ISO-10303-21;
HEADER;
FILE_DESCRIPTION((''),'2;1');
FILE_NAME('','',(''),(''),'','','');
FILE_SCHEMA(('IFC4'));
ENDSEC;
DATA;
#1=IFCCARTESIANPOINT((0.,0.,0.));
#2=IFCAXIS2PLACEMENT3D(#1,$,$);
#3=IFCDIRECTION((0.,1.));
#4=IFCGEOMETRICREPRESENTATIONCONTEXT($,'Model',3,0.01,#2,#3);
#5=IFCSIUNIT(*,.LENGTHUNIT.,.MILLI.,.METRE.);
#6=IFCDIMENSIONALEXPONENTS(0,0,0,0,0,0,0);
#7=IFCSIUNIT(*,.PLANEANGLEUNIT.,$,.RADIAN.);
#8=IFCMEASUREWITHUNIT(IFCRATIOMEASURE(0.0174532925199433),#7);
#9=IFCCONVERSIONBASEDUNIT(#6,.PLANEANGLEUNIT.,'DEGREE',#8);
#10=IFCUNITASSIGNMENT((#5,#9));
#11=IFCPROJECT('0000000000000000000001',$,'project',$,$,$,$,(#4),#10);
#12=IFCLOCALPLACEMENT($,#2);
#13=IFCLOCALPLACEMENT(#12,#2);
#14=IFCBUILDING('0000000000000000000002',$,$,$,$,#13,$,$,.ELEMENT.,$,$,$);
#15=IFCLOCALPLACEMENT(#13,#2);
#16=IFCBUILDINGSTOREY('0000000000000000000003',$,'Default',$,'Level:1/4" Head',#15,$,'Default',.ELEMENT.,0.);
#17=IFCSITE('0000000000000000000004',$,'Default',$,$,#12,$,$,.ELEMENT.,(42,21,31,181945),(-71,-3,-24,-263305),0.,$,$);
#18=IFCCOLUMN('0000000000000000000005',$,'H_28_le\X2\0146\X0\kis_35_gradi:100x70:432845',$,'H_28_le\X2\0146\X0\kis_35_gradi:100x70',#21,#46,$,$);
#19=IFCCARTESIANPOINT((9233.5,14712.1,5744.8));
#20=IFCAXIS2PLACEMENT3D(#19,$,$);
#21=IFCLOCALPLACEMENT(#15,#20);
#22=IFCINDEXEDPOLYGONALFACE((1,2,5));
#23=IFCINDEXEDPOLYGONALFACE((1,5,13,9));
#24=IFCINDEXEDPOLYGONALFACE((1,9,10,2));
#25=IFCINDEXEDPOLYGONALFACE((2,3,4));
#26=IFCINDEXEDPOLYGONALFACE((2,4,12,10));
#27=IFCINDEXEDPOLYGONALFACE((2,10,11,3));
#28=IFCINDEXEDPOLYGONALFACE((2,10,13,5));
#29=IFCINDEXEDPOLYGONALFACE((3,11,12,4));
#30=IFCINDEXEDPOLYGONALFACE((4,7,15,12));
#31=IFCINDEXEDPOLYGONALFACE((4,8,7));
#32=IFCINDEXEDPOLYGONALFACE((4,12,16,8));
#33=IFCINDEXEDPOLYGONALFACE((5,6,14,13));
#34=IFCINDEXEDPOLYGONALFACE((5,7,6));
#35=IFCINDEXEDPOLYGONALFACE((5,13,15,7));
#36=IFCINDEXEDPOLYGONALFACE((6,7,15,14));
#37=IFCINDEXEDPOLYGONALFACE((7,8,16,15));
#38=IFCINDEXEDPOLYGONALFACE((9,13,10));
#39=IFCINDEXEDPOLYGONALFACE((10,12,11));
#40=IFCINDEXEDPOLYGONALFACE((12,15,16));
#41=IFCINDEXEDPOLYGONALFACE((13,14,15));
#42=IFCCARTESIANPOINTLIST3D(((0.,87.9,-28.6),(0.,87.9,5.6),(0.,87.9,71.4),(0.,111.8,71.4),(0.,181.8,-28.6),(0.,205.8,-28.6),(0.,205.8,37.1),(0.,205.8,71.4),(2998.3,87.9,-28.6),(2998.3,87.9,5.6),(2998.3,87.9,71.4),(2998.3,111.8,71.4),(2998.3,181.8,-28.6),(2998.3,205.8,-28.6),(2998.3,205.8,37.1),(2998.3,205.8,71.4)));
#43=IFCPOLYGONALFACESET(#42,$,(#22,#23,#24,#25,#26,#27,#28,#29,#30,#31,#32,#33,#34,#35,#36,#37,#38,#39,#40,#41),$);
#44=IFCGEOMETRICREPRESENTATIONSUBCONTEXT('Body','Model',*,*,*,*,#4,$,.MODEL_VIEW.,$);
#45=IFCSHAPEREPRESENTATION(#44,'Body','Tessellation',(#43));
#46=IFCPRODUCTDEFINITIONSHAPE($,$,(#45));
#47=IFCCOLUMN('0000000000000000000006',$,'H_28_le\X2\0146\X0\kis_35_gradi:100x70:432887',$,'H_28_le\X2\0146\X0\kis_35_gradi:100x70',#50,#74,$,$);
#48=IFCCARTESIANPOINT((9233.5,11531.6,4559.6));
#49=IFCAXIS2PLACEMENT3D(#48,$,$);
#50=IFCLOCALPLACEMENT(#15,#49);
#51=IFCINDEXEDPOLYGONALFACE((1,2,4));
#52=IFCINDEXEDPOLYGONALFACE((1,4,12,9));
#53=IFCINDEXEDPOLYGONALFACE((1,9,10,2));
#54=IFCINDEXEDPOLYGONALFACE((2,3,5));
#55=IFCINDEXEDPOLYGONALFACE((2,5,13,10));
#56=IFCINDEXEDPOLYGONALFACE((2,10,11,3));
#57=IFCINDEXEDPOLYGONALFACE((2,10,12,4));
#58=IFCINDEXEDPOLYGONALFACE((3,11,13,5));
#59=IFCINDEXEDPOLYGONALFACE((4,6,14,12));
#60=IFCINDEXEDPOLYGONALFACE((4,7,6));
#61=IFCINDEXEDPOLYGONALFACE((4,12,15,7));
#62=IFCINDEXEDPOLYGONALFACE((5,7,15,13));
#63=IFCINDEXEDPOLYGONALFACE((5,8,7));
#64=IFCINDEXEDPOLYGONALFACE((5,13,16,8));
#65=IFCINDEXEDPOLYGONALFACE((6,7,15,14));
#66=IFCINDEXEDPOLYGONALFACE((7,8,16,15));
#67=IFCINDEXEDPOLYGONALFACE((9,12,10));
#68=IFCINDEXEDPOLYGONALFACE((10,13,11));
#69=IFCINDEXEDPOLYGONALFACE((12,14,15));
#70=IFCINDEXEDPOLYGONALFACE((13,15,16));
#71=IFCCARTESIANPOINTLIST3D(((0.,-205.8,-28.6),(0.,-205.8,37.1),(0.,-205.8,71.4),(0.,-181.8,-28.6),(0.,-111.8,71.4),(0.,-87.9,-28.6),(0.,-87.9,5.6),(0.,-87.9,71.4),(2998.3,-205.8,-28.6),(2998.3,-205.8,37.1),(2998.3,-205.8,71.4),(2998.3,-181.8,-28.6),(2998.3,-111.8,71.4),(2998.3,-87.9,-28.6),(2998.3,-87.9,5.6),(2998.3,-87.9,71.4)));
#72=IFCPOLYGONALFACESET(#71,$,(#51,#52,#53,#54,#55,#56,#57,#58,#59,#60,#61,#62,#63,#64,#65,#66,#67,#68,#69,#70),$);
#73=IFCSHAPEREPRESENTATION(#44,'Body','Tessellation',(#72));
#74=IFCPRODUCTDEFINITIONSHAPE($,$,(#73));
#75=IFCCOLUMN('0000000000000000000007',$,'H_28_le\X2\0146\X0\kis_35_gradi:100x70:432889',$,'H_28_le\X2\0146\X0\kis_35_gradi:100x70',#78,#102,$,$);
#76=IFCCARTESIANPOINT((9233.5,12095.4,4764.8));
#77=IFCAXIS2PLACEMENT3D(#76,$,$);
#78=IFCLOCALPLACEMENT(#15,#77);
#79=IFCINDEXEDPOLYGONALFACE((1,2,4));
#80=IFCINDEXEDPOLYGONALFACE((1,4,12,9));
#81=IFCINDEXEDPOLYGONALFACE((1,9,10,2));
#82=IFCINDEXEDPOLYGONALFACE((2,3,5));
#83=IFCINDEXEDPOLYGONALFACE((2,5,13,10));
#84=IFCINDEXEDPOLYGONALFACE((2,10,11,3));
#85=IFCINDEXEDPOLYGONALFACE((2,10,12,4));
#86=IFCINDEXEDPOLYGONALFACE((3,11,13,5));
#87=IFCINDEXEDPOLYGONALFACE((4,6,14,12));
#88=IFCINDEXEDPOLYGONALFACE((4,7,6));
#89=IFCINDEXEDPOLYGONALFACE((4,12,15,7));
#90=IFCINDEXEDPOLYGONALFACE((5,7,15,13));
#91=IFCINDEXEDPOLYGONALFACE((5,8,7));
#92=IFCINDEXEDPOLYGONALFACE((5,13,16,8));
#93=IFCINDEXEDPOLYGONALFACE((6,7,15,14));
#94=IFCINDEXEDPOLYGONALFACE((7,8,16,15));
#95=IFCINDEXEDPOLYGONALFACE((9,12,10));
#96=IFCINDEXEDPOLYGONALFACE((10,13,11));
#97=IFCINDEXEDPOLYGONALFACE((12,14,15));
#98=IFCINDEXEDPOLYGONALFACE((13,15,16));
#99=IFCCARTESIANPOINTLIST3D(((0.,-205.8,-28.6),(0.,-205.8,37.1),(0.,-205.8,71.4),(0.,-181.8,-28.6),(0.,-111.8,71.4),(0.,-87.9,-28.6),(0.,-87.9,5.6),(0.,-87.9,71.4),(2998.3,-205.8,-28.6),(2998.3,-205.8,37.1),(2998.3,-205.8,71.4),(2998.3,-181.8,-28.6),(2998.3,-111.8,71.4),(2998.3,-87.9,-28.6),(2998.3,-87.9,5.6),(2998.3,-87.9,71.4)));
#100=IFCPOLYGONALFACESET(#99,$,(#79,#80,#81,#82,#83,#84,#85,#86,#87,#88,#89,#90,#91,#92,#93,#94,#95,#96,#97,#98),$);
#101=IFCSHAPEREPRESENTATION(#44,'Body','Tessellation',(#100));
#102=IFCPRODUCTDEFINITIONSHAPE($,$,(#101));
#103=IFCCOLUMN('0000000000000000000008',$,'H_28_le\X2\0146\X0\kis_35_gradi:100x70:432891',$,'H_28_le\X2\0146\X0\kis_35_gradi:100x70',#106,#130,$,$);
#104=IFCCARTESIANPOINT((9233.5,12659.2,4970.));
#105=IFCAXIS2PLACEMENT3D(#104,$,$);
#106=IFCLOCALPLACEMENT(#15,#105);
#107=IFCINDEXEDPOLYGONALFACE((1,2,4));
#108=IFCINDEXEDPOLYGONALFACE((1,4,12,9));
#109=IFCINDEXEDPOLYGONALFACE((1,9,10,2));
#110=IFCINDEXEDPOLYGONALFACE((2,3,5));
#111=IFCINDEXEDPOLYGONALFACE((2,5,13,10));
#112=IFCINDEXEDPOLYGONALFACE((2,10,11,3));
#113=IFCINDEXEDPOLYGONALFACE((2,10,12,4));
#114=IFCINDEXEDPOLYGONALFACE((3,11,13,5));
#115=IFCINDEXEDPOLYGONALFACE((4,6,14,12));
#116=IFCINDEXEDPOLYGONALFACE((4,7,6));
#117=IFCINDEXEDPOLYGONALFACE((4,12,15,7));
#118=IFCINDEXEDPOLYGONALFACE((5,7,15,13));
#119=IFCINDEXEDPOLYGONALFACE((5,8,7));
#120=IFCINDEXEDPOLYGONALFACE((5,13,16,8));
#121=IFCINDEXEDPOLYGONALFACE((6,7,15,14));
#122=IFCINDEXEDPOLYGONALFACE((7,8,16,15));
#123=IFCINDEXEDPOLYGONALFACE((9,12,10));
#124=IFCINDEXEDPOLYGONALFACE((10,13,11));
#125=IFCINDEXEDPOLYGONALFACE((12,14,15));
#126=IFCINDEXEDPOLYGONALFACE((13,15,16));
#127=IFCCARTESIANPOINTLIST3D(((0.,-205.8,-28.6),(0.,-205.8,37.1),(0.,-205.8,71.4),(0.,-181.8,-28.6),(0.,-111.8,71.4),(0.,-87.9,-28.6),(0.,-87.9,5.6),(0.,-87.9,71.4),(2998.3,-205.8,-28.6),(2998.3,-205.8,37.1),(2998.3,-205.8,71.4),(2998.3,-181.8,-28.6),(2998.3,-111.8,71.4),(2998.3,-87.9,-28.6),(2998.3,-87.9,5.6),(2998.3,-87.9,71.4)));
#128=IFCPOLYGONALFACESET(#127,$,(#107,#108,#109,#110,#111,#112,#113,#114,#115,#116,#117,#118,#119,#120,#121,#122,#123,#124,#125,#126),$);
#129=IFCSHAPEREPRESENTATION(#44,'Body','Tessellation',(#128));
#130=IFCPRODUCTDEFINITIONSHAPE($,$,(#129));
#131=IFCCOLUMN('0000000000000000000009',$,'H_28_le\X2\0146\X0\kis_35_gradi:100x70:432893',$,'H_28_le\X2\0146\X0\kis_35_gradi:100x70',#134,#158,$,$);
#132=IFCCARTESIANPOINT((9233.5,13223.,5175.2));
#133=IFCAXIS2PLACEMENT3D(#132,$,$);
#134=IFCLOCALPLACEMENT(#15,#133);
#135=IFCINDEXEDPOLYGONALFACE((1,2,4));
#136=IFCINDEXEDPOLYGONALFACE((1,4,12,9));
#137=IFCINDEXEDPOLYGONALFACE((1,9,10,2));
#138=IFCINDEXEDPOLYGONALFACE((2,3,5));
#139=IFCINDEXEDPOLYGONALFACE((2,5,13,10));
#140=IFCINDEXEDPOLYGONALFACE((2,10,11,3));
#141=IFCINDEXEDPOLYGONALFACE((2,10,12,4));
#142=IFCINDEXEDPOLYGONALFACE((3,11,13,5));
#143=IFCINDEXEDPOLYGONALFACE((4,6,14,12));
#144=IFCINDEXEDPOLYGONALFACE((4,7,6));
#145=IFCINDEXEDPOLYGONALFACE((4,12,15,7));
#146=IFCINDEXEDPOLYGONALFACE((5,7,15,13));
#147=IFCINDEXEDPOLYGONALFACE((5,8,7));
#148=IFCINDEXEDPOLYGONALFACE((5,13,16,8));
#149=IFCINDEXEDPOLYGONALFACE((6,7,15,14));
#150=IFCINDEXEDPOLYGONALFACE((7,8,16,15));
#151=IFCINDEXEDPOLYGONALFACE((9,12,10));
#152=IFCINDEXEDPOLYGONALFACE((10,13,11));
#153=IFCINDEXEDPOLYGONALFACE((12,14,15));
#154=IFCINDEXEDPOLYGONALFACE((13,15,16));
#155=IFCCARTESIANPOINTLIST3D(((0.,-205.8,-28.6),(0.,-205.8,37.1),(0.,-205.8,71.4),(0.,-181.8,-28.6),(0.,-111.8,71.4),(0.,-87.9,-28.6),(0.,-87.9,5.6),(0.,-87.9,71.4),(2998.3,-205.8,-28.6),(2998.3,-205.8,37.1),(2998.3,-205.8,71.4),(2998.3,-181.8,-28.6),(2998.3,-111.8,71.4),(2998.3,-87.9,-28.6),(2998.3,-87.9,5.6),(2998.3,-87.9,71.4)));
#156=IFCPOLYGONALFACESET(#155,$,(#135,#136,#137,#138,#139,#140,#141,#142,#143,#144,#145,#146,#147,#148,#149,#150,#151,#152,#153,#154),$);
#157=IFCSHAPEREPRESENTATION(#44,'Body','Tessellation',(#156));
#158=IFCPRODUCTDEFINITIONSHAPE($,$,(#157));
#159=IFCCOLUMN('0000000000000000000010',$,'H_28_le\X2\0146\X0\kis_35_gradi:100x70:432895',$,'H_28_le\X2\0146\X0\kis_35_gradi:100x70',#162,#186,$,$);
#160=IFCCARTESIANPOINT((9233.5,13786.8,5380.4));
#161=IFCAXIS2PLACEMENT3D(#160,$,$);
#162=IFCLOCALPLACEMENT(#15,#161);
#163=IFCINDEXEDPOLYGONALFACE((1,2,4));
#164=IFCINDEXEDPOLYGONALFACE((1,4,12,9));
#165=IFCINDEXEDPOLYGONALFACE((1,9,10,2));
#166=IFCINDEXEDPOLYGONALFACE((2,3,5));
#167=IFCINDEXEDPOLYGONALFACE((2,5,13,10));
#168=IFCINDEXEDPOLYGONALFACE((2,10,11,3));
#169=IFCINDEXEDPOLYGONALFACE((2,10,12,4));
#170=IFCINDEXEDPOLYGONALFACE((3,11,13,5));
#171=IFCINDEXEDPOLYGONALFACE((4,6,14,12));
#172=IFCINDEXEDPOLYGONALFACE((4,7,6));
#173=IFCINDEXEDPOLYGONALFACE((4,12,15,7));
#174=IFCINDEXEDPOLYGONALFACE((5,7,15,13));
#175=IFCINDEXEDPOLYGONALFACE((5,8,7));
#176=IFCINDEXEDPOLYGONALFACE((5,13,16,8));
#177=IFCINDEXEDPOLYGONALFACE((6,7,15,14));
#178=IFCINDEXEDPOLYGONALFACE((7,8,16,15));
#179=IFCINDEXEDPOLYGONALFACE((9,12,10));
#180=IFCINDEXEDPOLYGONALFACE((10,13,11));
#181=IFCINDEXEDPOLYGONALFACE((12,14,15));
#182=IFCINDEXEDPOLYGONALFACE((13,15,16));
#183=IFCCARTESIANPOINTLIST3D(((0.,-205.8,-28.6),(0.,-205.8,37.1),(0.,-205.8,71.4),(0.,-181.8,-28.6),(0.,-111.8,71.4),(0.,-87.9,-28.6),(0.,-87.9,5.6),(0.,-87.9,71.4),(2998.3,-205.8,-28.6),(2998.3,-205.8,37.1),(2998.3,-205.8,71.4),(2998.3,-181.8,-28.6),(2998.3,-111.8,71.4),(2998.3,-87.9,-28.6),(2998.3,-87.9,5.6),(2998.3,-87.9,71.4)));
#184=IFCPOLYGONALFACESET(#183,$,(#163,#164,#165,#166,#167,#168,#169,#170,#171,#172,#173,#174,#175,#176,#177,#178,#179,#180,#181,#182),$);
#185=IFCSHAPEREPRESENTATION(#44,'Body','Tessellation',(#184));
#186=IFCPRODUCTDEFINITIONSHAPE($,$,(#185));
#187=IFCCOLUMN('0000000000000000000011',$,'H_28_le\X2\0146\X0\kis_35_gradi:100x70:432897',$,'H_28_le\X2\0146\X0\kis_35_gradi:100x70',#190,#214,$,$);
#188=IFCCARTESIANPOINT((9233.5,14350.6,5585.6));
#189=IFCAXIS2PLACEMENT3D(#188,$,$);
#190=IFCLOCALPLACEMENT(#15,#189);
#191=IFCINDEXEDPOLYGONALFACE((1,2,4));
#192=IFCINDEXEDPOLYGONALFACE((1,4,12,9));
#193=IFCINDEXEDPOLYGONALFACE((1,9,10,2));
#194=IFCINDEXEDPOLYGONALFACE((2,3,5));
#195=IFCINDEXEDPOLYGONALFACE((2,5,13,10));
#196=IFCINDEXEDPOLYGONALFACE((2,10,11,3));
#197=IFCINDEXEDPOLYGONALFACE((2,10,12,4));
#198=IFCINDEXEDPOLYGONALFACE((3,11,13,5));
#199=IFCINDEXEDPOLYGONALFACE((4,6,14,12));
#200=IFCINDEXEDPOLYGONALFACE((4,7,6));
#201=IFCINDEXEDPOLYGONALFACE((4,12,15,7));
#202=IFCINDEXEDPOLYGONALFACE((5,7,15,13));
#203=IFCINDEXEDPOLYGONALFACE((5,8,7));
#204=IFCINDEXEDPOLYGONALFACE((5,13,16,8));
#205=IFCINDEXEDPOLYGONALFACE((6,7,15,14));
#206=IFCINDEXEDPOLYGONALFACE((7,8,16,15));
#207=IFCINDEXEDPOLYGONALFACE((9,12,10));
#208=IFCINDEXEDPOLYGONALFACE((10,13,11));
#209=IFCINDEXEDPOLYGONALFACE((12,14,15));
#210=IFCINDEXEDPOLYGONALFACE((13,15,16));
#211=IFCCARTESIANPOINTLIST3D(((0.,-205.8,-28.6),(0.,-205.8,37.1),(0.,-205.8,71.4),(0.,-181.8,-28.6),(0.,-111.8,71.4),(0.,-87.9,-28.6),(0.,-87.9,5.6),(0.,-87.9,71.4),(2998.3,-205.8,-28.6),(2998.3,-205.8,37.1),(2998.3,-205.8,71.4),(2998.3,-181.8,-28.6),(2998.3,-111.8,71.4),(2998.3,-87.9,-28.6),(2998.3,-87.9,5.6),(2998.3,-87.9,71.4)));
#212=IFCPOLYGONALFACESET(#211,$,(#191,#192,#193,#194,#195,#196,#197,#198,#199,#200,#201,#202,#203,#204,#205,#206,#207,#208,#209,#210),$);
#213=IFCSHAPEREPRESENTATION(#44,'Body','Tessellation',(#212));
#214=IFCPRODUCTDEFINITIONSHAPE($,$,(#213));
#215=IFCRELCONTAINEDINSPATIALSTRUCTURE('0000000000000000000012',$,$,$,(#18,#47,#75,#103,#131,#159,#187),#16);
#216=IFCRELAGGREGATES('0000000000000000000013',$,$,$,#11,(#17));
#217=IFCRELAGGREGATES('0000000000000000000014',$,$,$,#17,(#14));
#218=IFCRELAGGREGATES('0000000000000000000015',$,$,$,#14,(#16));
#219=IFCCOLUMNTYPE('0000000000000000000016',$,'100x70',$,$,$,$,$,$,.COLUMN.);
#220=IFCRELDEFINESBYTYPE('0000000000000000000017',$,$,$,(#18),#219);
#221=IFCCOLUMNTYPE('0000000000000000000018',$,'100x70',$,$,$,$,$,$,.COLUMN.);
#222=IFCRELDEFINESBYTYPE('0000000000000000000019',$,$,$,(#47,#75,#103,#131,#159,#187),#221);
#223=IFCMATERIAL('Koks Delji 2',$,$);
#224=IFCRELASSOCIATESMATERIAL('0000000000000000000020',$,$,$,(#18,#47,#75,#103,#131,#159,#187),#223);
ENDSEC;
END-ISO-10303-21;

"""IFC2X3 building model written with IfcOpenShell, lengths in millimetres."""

from ifc_helpers import new_model, entity, si_unit, converted_unit, direction, frame, frame_2d, origin, place, context, subcontext, project, spatial, rectangle, extrude, boolean, source, transform, mapped, material, type_object, type_shapes, element, save


model = new_model("IFC2X3")

# Units and contexts
model_context = context("Model", 3, precision=0.01, world=origin(), true_north=direction((0.0, 1.0)))
body_context = subcontext(model_context, "Body", "Model", "MODEL_VIEW")
ifc_project = project(units=[si_unit("LENGTHUNIT", "METRE", prefix="MILLI"), converted_unit("PLANEANGLEUNIT", "DEGREE", entity("IfcRatioMeasure", 0.0174532925199433), si_unit("PLANEANGLEUNIT", "RADIAN"), dimensions=[0, 0, 0, 0, 0, 0, 0])], contexts=[model_context])

# Site, building, storey
site_placement = place(None, origin())
site = spatial("IfcSite", under=ifc_project, at=site_placement, Name="Default", CompositionType="ELEMENT", RefLatitude=(42, 21, 31, 181945), RefLongitude=(-71, -3, -24, -263305), RefElevation=0.0)
building_placement = place(site_placement, origin())
building = spatial("IfcBuilding", under=site, at=building_placement, CompositionType="ELEMENT")
storey_placement = place(building_placement, origin())
storey = spatial("IfcBuildingStorey", under=building, at=storey_placement, Name="Default", ObjectType="Level:1/4\" Head", LongName="Default", CompositionType="ELEMENT", Elevation=0.0)

# Columns
ifc_material_1 = material(Name="Koks Delji 2")
column_type_1 = type_object("IfcColumnType", Name="100x70", PredefinedType="COLUMN")
shared_shape_1 = source(origin(), body_context, "Body", "CSG", [
    boolean("DIFFERENCE", extrude(rectangle(XDim=2998.3, YDim=117.9, at=frame_2d((0.0, 0.0), x_axis=(1.0, 0.0))), frame((1499.1, 146.8, -28.6)), (0.0, 0.0, 1.0), 100.0), extrude(rectangle(XDim=70.0, YDim=100.0, at=frame_2d((0.0, 0.0), x_axis=(0.0, 1.0))), frame((2998.3, 146.8, 21.4), z_axis=(1.0, 0.0, 0.0), x_axis=(0.0, 0.939693, -0.34202)), (0.0, 0.0, -1.0), 2998.3)),
])
type_shapes(column_type_1, [shared_shape_1])
column_placement = place(storey_placement, frame((9233.5, 14712.1, 5744.8)))
element("IfcColumn", 1, at=column_placement, inside=storey, type_object=column_type_1, material=ifc_material_1, Name="H_28_leņkis_35_gradi:100x70:432845", ObjectType="H_28_leņkis_35_gradi:100x70", context=body_context, shape_type="MappedRepresentation", body=[
    mapped(shared_shape_1, transform((0.0, 0.0, 0.0), scale=1.0)),
])
column_type_2 = type_object("IfcColumnType", Name="100x70", PredefinedType="COLUMN")
shared_shape_2 = source(origin(), body_context, "Body", "CSG", [
    boolean("DIFFERENCE", extrude(rectangle(XDim=2998.3, YDim=117.9, at=frame_2d((0.0, 0.0), x_axis=(1.0, 0.0))), frame((1499.1, -146.8, -28.6)), (0.0, 0.0, 1.0), 100.0), extrude(rectangle(XDim=70.0, YDim=100.0, at=frame_2d((0.0, 0.0), x_axis=(0.0, 1.0))), frame((0.0, -146.8, 21.4), z_axis=(-1.0, 0.0, 0.0), x_axis=(0.0, -0.939693, -0.34202)), (0.0, 0.0, -1.0), 2998.3)),
])
type_shapes(column_type_2, [shared_shape_2])
for number, where, name in (
    (2, (9233.5, 11531.6, 4559.6), "H_28_leņkis_35_gradi:100x70:432887"),
    (3, (9233.5, 12095.4, 4764.8), "H_28_leņkis_35_gradi:100x70:432889"),
    (4, (9233.5, 12659.2, 4970.0), "H_28_leņkis_35_gradi:100x70:432891"),
    (5, (9233.5, 13223.0, 5175.2), "H_28_leņkis_35_gradi:100x70:432893"),
    (6, (9233.5, 13786.8, 5380.4), "H_28_leņkis_35_gradi:100x70:432895"),
    (7, (9233.5, 14350.6, 5585.6), "H_28_leņkis_35_gradi:100x70:432897"),
):
    element("IfcColumn", number, at=place(storey_placement, frame(where)), inside=storey, type_object=column_type_2, material=ifc_material_1, Name=name, ObjectType="H_28_leņkis_35_gradi:100x70", context=body_context, shape_type="MappedRepresentation", body=[
        mapped(shared_shape_2, transform((0.0, 0.0, 0.0), scale=1.0)),
    ])

save(model, "model.ifc")
